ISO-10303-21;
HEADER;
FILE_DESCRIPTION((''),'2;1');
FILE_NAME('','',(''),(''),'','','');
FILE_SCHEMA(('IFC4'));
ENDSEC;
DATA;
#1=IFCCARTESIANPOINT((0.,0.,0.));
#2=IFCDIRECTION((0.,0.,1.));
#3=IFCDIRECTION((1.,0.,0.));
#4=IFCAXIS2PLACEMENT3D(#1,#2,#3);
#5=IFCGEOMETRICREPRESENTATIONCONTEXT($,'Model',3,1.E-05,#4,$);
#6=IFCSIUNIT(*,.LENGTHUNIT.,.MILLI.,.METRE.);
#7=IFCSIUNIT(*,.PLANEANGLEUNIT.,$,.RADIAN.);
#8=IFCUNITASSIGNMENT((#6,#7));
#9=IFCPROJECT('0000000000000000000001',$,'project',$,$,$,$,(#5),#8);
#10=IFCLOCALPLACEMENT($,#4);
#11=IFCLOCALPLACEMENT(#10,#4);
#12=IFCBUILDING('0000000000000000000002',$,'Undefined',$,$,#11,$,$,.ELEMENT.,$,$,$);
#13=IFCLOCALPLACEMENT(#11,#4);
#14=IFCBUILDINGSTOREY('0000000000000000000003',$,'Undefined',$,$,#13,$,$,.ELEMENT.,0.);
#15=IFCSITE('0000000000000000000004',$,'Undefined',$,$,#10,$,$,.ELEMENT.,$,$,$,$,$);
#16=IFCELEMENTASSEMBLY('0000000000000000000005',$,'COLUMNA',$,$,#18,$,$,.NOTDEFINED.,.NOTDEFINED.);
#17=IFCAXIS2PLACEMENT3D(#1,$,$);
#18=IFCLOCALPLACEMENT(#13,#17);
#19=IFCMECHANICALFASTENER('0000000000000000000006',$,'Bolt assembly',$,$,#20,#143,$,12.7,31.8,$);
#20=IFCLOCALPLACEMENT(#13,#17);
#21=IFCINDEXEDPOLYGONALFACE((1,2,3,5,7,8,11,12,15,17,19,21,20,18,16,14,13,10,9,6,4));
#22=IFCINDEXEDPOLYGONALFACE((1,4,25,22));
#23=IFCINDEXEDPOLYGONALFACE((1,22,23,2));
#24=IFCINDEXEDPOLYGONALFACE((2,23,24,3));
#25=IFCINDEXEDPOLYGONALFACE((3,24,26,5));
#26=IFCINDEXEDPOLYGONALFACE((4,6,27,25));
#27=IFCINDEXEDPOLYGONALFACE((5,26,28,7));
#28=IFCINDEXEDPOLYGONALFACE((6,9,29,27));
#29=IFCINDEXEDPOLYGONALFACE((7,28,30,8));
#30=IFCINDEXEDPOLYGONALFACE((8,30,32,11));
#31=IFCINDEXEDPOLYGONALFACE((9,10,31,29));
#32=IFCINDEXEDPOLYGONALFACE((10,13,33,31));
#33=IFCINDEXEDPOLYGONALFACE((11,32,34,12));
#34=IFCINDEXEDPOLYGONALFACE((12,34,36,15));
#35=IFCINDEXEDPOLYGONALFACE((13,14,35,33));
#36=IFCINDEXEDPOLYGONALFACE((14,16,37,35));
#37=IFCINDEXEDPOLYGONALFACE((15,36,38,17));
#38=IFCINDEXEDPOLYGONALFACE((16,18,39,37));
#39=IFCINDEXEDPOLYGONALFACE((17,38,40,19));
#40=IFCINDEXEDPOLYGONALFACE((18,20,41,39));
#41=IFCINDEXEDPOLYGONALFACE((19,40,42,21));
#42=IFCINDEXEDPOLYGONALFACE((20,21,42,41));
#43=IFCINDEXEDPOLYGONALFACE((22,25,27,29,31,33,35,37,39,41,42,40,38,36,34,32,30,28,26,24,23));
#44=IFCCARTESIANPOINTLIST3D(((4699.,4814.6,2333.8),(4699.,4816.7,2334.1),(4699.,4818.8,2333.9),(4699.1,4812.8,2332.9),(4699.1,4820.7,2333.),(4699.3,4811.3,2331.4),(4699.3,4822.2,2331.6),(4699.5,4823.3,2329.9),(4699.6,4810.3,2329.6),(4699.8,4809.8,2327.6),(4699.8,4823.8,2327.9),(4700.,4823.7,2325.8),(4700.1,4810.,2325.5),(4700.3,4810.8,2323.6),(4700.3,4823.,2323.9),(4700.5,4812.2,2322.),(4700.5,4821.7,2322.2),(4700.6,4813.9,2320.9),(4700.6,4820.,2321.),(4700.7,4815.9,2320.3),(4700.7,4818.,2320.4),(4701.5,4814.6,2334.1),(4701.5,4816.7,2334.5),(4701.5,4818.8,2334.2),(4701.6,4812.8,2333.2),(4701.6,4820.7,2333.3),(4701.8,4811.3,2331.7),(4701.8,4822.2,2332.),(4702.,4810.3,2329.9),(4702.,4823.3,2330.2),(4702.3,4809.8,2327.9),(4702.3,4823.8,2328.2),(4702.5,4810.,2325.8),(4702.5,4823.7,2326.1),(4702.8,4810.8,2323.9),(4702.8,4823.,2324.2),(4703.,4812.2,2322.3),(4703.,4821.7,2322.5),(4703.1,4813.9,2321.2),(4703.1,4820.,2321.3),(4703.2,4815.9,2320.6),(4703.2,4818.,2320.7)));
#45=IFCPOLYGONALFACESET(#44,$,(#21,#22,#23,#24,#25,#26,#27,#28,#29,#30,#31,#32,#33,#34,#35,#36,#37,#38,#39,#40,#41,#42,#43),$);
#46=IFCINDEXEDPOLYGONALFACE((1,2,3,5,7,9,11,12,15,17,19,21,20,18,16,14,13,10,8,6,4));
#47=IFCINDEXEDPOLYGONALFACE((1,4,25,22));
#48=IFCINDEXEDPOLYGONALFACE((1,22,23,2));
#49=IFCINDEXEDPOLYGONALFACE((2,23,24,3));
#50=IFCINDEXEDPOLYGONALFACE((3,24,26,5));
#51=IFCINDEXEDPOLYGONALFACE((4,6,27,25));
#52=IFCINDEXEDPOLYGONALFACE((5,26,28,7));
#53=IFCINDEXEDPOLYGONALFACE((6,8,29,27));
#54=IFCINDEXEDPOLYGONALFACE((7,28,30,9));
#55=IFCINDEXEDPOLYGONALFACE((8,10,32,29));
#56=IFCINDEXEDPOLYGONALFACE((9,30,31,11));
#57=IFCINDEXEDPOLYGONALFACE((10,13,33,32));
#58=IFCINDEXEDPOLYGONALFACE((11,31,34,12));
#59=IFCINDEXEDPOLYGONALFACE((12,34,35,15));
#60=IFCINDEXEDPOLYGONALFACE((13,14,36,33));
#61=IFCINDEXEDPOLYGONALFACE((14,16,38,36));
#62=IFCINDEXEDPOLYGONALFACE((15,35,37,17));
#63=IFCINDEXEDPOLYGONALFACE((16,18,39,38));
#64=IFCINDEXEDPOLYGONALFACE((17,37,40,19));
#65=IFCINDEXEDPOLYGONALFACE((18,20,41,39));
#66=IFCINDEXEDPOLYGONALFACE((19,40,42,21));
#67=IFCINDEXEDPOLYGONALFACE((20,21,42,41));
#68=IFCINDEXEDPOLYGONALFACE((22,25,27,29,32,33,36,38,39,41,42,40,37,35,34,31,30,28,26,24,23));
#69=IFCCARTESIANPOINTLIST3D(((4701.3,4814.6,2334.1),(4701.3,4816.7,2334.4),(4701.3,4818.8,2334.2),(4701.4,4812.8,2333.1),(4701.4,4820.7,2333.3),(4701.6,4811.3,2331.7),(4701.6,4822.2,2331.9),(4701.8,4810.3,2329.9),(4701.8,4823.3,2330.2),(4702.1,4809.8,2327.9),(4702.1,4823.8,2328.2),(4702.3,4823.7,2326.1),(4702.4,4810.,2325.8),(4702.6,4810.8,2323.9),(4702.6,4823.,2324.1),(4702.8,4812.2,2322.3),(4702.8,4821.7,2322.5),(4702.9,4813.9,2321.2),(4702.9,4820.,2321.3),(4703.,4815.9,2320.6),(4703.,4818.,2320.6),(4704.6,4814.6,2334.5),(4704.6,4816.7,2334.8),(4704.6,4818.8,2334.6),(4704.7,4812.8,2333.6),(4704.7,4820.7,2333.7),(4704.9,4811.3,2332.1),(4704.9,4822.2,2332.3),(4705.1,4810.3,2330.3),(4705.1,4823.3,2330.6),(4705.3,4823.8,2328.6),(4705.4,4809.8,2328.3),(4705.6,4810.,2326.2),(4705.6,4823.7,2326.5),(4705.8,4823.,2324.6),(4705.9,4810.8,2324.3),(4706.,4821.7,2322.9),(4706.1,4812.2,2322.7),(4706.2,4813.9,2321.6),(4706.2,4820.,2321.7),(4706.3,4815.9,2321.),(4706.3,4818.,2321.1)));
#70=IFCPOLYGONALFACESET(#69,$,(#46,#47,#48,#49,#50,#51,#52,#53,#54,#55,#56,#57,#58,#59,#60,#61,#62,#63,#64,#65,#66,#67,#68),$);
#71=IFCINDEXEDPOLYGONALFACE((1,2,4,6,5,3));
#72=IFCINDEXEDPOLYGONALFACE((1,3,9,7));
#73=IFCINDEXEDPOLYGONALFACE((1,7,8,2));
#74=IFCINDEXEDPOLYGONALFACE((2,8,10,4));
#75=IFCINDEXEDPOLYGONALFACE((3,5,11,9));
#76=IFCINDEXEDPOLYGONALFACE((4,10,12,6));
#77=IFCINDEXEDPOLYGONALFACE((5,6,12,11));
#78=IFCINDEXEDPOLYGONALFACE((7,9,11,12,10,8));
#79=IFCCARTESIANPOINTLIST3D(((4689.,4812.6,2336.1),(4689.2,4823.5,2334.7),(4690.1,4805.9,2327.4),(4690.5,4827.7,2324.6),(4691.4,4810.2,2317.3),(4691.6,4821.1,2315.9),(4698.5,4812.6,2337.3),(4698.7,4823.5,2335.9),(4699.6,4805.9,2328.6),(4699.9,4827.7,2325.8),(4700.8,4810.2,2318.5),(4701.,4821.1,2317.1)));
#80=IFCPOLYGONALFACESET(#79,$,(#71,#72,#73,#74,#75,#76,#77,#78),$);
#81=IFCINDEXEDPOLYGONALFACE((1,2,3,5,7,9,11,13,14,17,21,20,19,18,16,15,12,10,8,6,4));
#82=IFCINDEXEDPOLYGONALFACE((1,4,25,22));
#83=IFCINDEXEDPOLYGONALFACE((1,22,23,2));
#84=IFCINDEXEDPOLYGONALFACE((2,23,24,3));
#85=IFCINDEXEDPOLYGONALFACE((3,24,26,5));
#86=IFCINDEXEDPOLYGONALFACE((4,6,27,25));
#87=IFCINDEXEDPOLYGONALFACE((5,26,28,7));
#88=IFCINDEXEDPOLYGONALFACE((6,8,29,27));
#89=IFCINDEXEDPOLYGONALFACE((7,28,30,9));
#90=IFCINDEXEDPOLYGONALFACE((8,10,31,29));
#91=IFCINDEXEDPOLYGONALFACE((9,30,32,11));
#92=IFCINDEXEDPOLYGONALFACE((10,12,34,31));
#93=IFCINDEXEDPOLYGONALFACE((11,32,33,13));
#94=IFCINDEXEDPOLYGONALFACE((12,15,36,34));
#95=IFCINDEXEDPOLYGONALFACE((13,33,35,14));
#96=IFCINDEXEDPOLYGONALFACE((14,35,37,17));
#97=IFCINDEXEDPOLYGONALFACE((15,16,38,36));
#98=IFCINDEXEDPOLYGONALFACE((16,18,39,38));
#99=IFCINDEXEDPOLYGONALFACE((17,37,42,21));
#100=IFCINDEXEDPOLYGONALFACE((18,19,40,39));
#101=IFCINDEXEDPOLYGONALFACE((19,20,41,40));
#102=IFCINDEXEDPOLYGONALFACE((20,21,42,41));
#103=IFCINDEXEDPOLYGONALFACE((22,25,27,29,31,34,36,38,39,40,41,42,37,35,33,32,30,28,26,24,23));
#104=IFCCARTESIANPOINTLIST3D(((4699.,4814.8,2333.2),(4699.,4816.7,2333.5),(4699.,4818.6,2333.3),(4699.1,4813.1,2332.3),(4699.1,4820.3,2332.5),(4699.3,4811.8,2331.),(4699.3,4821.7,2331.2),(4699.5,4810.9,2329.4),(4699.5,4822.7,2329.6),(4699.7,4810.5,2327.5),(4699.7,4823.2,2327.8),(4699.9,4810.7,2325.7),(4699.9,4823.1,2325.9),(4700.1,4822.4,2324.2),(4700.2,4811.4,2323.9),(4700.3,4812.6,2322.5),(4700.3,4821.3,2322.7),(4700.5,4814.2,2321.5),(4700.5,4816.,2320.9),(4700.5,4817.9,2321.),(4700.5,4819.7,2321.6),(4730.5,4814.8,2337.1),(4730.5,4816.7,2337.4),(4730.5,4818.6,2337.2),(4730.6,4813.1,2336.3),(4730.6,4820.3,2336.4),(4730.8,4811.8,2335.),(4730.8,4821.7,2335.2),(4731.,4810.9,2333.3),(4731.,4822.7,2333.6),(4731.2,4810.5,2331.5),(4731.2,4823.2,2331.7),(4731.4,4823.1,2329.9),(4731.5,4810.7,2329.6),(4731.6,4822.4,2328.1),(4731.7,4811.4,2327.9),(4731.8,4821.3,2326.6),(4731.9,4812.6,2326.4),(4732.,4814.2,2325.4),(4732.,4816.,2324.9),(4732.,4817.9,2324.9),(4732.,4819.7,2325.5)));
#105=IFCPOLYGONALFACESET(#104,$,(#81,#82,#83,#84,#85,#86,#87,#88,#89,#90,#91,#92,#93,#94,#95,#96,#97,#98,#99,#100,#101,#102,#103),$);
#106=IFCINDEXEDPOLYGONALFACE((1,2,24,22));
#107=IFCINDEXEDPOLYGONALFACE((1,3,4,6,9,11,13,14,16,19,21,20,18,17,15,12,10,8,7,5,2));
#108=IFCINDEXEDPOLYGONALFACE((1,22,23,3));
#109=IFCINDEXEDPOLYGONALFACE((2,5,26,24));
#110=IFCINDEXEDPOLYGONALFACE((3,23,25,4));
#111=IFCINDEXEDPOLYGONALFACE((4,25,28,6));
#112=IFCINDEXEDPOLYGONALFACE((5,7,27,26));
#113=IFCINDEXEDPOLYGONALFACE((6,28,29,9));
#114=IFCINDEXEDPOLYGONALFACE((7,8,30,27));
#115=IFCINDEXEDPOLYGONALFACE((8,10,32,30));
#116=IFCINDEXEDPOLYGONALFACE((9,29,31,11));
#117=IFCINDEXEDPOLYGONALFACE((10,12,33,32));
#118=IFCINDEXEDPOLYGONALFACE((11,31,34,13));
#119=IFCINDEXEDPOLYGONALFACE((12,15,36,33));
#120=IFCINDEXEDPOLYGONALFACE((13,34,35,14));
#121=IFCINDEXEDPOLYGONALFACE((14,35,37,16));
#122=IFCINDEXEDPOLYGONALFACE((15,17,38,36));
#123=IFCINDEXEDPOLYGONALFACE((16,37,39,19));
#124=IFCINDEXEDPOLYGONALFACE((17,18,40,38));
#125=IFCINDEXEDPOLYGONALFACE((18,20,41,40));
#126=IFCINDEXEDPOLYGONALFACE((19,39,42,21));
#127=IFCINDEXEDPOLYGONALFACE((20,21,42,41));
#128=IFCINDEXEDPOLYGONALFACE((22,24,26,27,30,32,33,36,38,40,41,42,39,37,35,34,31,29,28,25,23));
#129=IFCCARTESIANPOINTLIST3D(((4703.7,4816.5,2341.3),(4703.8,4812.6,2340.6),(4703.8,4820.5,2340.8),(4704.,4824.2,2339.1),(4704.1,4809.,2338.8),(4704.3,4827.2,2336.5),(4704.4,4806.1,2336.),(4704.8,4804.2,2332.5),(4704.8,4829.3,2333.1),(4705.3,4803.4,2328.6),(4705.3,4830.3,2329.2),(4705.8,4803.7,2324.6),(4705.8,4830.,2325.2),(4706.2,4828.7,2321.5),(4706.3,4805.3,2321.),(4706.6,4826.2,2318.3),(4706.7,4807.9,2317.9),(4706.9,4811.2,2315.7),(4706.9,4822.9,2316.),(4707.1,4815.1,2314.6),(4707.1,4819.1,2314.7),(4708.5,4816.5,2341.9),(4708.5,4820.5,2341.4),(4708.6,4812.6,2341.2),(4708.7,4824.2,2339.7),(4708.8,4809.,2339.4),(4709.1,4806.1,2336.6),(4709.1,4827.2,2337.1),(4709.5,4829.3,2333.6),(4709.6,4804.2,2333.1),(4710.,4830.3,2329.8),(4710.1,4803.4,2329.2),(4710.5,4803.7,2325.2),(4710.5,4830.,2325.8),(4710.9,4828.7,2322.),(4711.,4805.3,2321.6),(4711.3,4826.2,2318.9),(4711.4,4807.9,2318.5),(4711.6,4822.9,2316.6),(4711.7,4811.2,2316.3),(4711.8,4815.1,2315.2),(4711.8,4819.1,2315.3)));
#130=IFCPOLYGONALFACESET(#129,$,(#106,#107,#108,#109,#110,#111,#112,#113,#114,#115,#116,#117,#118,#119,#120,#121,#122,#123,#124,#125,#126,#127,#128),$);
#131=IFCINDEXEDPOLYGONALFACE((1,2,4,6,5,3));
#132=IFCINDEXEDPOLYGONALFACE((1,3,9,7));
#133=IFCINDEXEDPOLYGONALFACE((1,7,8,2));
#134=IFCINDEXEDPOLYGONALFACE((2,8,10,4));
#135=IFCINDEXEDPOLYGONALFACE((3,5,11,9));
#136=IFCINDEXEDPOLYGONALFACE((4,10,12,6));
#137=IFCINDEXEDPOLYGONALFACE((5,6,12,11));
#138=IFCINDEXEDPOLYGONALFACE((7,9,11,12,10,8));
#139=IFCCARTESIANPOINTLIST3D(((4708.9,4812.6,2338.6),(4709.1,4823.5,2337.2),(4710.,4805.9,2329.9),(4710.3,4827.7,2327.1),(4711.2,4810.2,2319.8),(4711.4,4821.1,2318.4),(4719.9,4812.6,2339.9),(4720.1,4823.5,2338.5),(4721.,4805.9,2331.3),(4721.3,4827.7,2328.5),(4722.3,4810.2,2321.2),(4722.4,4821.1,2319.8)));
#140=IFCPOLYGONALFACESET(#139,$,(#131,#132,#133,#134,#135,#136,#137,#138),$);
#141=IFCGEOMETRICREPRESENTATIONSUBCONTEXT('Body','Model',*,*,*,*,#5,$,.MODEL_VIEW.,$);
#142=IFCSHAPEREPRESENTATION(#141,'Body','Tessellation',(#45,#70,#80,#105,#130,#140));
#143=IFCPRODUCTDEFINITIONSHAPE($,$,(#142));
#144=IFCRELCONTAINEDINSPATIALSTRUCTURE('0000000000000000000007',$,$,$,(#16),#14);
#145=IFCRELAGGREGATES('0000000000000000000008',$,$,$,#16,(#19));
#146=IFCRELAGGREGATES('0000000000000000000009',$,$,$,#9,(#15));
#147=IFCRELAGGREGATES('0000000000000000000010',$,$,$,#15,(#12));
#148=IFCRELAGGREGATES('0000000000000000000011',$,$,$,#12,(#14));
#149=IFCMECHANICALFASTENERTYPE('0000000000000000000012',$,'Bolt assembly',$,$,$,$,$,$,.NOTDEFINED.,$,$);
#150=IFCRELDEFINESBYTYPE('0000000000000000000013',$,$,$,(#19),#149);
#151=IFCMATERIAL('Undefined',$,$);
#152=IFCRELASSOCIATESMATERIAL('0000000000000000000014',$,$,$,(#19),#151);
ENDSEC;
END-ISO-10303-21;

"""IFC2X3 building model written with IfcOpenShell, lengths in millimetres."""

from ifc_helpers import new_model, si_unit, frame, origin_with_axes, origin_2d_with_axis, place, context, subcontext, project, spatial, polyline, circle, outline, extrude, source, transform, mapped, material, type_object, element, aggregate, save


model = new_model("IFC2X3")

# Units and contexts
model_context = context("Model", 3, precision=1e-05, world=origin_with_axes())
body_context = subcontext(model_context, "Body", "Model", "MODEL_VIEW")
ifc_project = project(units=[si_unit("LENGTHUNIT", "METRE", prefix="MILLI"), si_unit("PLANEANGLEUNIT", "RADIAN")], contexts=[model_context])

# Site, building, storey
site_placement = place(None, origin_with_axes())
site = spatial("IfcSite", under=ifc_project, at=site_placement, Name="Undefined", CompositionType="ELEMENT")
building_placement = place(site_placement, origin_with_axes())
building = spatial("IfcBuilding", under=site, at=building_placement, Name="Undefined", CompositionType="ELEMENT")
storey_placement = place(building_placement, origin_with_axes())
storey = spatial("IfcBuildingStorey", under=building, at=storey_placement, Name="Undefined", CompositionType="ELEMENT", Elevation=0.0)

# Element assembly
assembly_1_placement = place(storey_placement, origin_with_axes())
assembly_1 = element("IfcElementAssembly", 1, at=assembly_1_placement, inside=storey, Name="COLUMNA", AssemblyPlace="NOTDEFINED", PredefinedType="NOTDEFINED")

# Shared definitions
ifc_material_1 = material(Name="Undefined")
mechanical_fastener_type = type_object("IfcMechanicalFastenerType", Name="Bolt assembly")

# Mechanical fastener
shared_shape_1 = source(origin_with_axes(), body_context, "Body", "SweptSolid", [
    extrude(circle(Radius=7.0, at=origin_2d_with_axis()), frame((0.0, -2.4, 0.0), z_axis=(0.0, 1.0, 0.0), x_axis=(1.0, 0.0, 0.0)), (0.0, 0.0, 1.0), 2.5),
    extrude(circle(Radius=7.0, at=origin_2d_with_axis()), frame((0.0, -0.1, 0.0), z_axis=(0.0, 1.0, 0.0), x_axis=(1.0, 0.0, 0.0)), (0.0, 0.0, 1.0), 3.3),
    extrude(outline(polyline([(9.5, -5.5), (9.5, 5.5), (0.0, 11.0), (-9.5, 5.5), (-9.5, -5.5), (0.0, -11.0), (9.5, -5.5)])), frame((0.0, -12.0, 0.0), z_axis=(0.0, 1.0, 0.0), x_axis=(1.0, 0.0, 0.0)), (0.0, 0.0, 1.0), 9.5),
    extrude(circle(Radius=6.3, at=origin_2d_with_axis()), frame((0.0, -2.5, 0.0), z_axis=(0.0, 1.0, 0.0), x_axis=(1.0, 0.0, 0.0)), (0.0, 0.0, 1.0), 31.8),
    extrude(circle(Radius=13.5, at=origin_2d_with_axis()), frame((0.0, 3.2, 0.0), z_axis=(0.0, 1.0, 0.0), x_axis=(1.0, 0.0, 0.0)), (0.0, 0.0, 1.0), 4.8),
    extrude(outline(polyline([(9.5, -5.5), (9.5, 5.5), (0.0, 11.0), (-9.5, 5.5), (-9.5, -5.5), (0.0, -11.0), (9.5, -5.5)])), frame((0.0, 8.0, 0.0), z_axis=(0.0, 1.0, 0.0), x_axis=(1.0, 0.0, 0.0)), (0.0, 0.0, 1.0), 11.1),
])
mechanical_fastener_1_placement = place(assembly_1_placement, frame((4702.2, 4816.8, 2327.5), z_axis=(-0.098611, 0.606774, 0.788734), x_axis=(-0.075276, -0.794875, 0.602086)))
mechanical_fastener_1 = element("IfcMechanicalFastener", 2, at=mechanical_fastener_1_placement, type_object=mechanical_fastener_type, material=ifc_material_1, Name="Bolt assembly", NominalDiameter=12.7, NominalLength=31.8, context=body_context, shape_type="MappedRepresentation", body=[
    mapped(shared_shape_1, transform((0.0, 0.0, 0.0))),
])
aggregate(assembly_1, [mechanical_fastener_1])

save(model, "model.ifc")
